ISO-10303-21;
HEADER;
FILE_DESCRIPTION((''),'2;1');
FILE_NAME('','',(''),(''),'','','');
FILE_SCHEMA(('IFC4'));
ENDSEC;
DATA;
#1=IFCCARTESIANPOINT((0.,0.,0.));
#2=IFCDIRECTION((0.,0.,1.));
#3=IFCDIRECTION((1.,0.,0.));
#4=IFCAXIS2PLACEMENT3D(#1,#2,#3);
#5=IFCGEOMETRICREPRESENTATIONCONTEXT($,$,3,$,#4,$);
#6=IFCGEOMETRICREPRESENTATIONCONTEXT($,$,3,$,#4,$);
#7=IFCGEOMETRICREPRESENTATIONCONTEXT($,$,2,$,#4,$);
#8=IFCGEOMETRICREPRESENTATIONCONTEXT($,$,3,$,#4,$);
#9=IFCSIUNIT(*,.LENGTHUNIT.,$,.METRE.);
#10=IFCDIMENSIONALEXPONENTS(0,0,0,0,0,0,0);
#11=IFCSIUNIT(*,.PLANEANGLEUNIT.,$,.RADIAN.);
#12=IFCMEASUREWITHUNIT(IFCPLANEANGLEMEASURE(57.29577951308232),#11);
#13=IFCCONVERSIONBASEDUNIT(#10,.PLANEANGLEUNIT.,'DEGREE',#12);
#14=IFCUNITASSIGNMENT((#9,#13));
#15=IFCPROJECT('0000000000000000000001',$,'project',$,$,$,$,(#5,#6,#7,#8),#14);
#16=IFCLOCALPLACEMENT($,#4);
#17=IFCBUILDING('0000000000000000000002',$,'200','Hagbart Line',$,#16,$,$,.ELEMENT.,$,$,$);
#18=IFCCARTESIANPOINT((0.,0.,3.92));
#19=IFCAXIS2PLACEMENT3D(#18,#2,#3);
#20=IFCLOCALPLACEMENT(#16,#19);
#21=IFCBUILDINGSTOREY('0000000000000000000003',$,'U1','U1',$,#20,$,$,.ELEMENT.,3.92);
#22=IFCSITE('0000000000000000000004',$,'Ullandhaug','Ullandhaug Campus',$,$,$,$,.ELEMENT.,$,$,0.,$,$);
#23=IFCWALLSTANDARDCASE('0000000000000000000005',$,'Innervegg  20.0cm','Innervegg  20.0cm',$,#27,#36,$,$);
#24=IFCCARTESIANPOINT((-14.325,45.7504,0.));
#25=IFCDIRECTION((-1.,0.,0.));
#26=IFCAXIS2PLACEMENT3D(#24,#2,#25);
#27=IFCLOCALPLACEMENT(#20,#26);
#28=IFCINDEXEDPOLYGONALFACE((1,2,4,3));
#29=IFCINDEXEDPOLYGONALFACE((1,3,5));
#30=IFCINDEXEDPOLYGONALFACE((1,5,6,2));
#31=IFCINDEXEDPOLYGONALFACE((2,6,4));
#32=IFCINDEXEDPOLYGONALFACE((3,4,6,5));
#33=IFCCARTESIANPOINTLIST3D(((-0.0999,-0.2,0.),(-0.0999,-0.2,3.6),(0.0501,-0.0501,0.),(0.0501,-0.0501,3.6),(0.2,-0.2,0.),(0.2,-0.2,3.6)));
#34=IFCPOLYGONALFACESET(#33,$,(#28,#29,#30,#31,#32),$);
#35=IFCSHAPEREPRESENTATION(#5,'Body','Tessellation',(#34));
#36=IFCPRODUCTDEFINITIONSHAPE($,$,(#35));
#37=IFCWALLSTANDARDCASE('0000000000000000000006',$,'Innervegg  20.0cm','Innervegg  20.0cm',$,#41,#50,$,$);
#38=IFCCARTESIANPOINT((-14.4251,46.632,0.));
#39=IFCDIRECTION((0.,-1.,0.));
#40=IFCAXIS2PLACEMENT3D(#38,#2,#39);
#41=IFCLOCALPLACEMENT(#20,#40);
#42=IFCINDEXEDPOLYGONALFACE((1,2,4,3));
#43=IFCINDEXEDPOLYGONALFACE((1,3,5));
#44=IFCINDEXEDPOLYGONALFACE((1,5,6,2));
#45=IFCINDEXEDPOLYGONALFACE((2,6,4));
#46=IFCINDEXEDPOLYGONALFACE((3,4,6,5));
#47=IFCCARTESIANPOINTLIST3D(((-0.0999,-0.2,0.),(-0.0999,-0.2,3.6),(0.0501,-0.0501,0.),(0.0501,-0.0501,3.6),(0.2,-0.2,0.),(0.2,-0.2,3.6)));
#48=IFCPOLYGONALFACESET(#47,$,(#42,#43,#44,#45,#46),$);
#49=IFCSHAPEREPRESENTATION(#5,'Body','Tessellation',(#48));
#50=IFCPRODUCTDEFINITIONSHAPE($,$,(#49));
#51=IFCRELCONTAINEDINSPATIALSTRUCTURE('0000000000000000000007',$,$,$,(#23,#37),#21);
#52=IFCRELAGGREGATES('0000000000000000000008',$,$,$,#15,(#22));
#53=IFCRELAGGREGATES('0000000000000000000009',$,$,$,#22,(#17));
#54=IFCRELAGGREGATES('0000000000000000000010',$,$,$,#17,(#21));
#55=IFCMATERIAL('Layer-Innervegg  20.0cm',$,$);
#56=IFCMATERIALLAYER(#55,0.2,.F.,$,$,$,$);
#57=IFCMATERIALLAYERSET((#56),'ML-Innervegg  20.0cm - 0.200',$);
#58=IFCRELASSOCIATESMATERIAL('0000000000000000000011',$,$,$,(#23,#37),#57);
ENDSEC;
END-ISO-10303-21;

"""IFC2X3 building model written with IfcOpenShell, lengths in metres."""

from ifc_helpers import new_model, entity, si_unit, converted_unit, frame, origin_with_axes, place, context, project, spatial, polyline, outline, extrude, material, layer, layer_set, layer_usage, element, save


model = new_model("IFC2X3")

# Units and contexts
context_of_model_1 = context(None, 3, world=origin_with_axes())
context_of_model_2 = context(None, 3, world=origin_with_axes())
context_of_model_3 = context(None, 2, world=origin_with_axes())
context_of_model_4 = context(None, 3, world=origin_with_axes())
ifc_project = project(units=[si_unit("LENGTHUNIT", "METRE"), converted_unit("PLANEANGLEUNIT", "DEGREE", entity("IfcPlaneAngleMeasure", 57.29577951308232), si_unit("PLANEANGLEUNIT", "RADIAN"), dimensions=[0, 0, 0, 0, 0, 0, 0])], contexts=[context_of_model_1, context_of_model_2, context_of_model_3, context_of_model_4])

# Site, building, storey
site = spatial("IfcSite", under=ifc_project, Name="Ullandhaug", Description="Ullandhaug Campus", CompositionType="ELEMENT", RefElevation=0.0)
building_placement = place(None, origin_with_axes())
building = spatial("IfcBuilding", under=site, at=building_placement, Name="200", Description="Hagbart Line", CompositionType="ELEMENT")
storey_placement = place(building_placement, frame((0.0, 0.0, 3.92), z_axis=(0.0, 0.0, 1.0), x_axis=(1.0, 0.0, 0.0)))
storey = spatial("IfcBuildingStorey", under=building, at=storey_placement, Name="U1", Description="U1", CompositionType="ELEMENT", Elevation=3.92)

# Shared definitions
ifc_material_1 = material(Name="Layer-Innervegg  20.0cm")
ifc_layer_1 = layer(ifc_material_1, 0.2, ventilated=False)
ifc_layer_set_1 = layer_set([ifc_layer_1], Name="ML-Innervegg  20.0cm - 0.200")
ifc_layer_usage_1 = layer_usage(ifc_layer_set_1, "AXIS2", "POSITIVE", 0.0)

# Walls
wall_1_placement = place(storey_placement, frame((-14.325, 45.7504, 0.0), z_axis=(0.0, 0.0, 1.0), x_axis=(-1.0, 0.0, 0.0)))
element("IfcWallStandardCase", 1, at=wall_1_placement, inside=storey, material=ifc_layer_usage_1, Name="Innervegg  20.0cm", Description="Innervegg  20.0cm", context=context_of_model_1, shape_type="SweptSolid", body=[
    extrude(outline(polyline([(0.0, 0.0), (0.1001, 0.0), (-0.0999, 0.2), (0.2, 0.2), (0.0, 0.0)])), frame((0.0, 0.0, 0.0), z_axis=(0.0, 0.0, -1.0), x_axis=(1.0, 0.0, 0.0)), (0.0, 0.0, -1.0), 3.6),
])
wall_2_placement = place(storey_placement, frame((-14.4251, 46.632, 0.0), z_axis=(0.0, 0.0, 1.0), x_axis=(0.0, -1.0, 0.0)))
element("IfcWallStandardCase", 2, at=wall_2_placement, inside=storey, material=ifc_layer_usage_1, Name="Innervegg  20.0cm", Description="Innervegg  20.0cm", context=context_of_model_1, shape_type="SweptSolid", body=[
    extrude(outline(polyline([(0.0, 0.0), (0.1001, 0.0), (-0.0999, 0.2), (0.2, 0.2), (0.0, 0.0)])), frame((0.0, 0.0, 0.0), z_axis=(0.0, 0.0, -1.0), x_axis=(1.0, 0.0, 0.0)), (0.0, 0.0, -1.0), 3.6),
])

save(model, "model.ifc")
